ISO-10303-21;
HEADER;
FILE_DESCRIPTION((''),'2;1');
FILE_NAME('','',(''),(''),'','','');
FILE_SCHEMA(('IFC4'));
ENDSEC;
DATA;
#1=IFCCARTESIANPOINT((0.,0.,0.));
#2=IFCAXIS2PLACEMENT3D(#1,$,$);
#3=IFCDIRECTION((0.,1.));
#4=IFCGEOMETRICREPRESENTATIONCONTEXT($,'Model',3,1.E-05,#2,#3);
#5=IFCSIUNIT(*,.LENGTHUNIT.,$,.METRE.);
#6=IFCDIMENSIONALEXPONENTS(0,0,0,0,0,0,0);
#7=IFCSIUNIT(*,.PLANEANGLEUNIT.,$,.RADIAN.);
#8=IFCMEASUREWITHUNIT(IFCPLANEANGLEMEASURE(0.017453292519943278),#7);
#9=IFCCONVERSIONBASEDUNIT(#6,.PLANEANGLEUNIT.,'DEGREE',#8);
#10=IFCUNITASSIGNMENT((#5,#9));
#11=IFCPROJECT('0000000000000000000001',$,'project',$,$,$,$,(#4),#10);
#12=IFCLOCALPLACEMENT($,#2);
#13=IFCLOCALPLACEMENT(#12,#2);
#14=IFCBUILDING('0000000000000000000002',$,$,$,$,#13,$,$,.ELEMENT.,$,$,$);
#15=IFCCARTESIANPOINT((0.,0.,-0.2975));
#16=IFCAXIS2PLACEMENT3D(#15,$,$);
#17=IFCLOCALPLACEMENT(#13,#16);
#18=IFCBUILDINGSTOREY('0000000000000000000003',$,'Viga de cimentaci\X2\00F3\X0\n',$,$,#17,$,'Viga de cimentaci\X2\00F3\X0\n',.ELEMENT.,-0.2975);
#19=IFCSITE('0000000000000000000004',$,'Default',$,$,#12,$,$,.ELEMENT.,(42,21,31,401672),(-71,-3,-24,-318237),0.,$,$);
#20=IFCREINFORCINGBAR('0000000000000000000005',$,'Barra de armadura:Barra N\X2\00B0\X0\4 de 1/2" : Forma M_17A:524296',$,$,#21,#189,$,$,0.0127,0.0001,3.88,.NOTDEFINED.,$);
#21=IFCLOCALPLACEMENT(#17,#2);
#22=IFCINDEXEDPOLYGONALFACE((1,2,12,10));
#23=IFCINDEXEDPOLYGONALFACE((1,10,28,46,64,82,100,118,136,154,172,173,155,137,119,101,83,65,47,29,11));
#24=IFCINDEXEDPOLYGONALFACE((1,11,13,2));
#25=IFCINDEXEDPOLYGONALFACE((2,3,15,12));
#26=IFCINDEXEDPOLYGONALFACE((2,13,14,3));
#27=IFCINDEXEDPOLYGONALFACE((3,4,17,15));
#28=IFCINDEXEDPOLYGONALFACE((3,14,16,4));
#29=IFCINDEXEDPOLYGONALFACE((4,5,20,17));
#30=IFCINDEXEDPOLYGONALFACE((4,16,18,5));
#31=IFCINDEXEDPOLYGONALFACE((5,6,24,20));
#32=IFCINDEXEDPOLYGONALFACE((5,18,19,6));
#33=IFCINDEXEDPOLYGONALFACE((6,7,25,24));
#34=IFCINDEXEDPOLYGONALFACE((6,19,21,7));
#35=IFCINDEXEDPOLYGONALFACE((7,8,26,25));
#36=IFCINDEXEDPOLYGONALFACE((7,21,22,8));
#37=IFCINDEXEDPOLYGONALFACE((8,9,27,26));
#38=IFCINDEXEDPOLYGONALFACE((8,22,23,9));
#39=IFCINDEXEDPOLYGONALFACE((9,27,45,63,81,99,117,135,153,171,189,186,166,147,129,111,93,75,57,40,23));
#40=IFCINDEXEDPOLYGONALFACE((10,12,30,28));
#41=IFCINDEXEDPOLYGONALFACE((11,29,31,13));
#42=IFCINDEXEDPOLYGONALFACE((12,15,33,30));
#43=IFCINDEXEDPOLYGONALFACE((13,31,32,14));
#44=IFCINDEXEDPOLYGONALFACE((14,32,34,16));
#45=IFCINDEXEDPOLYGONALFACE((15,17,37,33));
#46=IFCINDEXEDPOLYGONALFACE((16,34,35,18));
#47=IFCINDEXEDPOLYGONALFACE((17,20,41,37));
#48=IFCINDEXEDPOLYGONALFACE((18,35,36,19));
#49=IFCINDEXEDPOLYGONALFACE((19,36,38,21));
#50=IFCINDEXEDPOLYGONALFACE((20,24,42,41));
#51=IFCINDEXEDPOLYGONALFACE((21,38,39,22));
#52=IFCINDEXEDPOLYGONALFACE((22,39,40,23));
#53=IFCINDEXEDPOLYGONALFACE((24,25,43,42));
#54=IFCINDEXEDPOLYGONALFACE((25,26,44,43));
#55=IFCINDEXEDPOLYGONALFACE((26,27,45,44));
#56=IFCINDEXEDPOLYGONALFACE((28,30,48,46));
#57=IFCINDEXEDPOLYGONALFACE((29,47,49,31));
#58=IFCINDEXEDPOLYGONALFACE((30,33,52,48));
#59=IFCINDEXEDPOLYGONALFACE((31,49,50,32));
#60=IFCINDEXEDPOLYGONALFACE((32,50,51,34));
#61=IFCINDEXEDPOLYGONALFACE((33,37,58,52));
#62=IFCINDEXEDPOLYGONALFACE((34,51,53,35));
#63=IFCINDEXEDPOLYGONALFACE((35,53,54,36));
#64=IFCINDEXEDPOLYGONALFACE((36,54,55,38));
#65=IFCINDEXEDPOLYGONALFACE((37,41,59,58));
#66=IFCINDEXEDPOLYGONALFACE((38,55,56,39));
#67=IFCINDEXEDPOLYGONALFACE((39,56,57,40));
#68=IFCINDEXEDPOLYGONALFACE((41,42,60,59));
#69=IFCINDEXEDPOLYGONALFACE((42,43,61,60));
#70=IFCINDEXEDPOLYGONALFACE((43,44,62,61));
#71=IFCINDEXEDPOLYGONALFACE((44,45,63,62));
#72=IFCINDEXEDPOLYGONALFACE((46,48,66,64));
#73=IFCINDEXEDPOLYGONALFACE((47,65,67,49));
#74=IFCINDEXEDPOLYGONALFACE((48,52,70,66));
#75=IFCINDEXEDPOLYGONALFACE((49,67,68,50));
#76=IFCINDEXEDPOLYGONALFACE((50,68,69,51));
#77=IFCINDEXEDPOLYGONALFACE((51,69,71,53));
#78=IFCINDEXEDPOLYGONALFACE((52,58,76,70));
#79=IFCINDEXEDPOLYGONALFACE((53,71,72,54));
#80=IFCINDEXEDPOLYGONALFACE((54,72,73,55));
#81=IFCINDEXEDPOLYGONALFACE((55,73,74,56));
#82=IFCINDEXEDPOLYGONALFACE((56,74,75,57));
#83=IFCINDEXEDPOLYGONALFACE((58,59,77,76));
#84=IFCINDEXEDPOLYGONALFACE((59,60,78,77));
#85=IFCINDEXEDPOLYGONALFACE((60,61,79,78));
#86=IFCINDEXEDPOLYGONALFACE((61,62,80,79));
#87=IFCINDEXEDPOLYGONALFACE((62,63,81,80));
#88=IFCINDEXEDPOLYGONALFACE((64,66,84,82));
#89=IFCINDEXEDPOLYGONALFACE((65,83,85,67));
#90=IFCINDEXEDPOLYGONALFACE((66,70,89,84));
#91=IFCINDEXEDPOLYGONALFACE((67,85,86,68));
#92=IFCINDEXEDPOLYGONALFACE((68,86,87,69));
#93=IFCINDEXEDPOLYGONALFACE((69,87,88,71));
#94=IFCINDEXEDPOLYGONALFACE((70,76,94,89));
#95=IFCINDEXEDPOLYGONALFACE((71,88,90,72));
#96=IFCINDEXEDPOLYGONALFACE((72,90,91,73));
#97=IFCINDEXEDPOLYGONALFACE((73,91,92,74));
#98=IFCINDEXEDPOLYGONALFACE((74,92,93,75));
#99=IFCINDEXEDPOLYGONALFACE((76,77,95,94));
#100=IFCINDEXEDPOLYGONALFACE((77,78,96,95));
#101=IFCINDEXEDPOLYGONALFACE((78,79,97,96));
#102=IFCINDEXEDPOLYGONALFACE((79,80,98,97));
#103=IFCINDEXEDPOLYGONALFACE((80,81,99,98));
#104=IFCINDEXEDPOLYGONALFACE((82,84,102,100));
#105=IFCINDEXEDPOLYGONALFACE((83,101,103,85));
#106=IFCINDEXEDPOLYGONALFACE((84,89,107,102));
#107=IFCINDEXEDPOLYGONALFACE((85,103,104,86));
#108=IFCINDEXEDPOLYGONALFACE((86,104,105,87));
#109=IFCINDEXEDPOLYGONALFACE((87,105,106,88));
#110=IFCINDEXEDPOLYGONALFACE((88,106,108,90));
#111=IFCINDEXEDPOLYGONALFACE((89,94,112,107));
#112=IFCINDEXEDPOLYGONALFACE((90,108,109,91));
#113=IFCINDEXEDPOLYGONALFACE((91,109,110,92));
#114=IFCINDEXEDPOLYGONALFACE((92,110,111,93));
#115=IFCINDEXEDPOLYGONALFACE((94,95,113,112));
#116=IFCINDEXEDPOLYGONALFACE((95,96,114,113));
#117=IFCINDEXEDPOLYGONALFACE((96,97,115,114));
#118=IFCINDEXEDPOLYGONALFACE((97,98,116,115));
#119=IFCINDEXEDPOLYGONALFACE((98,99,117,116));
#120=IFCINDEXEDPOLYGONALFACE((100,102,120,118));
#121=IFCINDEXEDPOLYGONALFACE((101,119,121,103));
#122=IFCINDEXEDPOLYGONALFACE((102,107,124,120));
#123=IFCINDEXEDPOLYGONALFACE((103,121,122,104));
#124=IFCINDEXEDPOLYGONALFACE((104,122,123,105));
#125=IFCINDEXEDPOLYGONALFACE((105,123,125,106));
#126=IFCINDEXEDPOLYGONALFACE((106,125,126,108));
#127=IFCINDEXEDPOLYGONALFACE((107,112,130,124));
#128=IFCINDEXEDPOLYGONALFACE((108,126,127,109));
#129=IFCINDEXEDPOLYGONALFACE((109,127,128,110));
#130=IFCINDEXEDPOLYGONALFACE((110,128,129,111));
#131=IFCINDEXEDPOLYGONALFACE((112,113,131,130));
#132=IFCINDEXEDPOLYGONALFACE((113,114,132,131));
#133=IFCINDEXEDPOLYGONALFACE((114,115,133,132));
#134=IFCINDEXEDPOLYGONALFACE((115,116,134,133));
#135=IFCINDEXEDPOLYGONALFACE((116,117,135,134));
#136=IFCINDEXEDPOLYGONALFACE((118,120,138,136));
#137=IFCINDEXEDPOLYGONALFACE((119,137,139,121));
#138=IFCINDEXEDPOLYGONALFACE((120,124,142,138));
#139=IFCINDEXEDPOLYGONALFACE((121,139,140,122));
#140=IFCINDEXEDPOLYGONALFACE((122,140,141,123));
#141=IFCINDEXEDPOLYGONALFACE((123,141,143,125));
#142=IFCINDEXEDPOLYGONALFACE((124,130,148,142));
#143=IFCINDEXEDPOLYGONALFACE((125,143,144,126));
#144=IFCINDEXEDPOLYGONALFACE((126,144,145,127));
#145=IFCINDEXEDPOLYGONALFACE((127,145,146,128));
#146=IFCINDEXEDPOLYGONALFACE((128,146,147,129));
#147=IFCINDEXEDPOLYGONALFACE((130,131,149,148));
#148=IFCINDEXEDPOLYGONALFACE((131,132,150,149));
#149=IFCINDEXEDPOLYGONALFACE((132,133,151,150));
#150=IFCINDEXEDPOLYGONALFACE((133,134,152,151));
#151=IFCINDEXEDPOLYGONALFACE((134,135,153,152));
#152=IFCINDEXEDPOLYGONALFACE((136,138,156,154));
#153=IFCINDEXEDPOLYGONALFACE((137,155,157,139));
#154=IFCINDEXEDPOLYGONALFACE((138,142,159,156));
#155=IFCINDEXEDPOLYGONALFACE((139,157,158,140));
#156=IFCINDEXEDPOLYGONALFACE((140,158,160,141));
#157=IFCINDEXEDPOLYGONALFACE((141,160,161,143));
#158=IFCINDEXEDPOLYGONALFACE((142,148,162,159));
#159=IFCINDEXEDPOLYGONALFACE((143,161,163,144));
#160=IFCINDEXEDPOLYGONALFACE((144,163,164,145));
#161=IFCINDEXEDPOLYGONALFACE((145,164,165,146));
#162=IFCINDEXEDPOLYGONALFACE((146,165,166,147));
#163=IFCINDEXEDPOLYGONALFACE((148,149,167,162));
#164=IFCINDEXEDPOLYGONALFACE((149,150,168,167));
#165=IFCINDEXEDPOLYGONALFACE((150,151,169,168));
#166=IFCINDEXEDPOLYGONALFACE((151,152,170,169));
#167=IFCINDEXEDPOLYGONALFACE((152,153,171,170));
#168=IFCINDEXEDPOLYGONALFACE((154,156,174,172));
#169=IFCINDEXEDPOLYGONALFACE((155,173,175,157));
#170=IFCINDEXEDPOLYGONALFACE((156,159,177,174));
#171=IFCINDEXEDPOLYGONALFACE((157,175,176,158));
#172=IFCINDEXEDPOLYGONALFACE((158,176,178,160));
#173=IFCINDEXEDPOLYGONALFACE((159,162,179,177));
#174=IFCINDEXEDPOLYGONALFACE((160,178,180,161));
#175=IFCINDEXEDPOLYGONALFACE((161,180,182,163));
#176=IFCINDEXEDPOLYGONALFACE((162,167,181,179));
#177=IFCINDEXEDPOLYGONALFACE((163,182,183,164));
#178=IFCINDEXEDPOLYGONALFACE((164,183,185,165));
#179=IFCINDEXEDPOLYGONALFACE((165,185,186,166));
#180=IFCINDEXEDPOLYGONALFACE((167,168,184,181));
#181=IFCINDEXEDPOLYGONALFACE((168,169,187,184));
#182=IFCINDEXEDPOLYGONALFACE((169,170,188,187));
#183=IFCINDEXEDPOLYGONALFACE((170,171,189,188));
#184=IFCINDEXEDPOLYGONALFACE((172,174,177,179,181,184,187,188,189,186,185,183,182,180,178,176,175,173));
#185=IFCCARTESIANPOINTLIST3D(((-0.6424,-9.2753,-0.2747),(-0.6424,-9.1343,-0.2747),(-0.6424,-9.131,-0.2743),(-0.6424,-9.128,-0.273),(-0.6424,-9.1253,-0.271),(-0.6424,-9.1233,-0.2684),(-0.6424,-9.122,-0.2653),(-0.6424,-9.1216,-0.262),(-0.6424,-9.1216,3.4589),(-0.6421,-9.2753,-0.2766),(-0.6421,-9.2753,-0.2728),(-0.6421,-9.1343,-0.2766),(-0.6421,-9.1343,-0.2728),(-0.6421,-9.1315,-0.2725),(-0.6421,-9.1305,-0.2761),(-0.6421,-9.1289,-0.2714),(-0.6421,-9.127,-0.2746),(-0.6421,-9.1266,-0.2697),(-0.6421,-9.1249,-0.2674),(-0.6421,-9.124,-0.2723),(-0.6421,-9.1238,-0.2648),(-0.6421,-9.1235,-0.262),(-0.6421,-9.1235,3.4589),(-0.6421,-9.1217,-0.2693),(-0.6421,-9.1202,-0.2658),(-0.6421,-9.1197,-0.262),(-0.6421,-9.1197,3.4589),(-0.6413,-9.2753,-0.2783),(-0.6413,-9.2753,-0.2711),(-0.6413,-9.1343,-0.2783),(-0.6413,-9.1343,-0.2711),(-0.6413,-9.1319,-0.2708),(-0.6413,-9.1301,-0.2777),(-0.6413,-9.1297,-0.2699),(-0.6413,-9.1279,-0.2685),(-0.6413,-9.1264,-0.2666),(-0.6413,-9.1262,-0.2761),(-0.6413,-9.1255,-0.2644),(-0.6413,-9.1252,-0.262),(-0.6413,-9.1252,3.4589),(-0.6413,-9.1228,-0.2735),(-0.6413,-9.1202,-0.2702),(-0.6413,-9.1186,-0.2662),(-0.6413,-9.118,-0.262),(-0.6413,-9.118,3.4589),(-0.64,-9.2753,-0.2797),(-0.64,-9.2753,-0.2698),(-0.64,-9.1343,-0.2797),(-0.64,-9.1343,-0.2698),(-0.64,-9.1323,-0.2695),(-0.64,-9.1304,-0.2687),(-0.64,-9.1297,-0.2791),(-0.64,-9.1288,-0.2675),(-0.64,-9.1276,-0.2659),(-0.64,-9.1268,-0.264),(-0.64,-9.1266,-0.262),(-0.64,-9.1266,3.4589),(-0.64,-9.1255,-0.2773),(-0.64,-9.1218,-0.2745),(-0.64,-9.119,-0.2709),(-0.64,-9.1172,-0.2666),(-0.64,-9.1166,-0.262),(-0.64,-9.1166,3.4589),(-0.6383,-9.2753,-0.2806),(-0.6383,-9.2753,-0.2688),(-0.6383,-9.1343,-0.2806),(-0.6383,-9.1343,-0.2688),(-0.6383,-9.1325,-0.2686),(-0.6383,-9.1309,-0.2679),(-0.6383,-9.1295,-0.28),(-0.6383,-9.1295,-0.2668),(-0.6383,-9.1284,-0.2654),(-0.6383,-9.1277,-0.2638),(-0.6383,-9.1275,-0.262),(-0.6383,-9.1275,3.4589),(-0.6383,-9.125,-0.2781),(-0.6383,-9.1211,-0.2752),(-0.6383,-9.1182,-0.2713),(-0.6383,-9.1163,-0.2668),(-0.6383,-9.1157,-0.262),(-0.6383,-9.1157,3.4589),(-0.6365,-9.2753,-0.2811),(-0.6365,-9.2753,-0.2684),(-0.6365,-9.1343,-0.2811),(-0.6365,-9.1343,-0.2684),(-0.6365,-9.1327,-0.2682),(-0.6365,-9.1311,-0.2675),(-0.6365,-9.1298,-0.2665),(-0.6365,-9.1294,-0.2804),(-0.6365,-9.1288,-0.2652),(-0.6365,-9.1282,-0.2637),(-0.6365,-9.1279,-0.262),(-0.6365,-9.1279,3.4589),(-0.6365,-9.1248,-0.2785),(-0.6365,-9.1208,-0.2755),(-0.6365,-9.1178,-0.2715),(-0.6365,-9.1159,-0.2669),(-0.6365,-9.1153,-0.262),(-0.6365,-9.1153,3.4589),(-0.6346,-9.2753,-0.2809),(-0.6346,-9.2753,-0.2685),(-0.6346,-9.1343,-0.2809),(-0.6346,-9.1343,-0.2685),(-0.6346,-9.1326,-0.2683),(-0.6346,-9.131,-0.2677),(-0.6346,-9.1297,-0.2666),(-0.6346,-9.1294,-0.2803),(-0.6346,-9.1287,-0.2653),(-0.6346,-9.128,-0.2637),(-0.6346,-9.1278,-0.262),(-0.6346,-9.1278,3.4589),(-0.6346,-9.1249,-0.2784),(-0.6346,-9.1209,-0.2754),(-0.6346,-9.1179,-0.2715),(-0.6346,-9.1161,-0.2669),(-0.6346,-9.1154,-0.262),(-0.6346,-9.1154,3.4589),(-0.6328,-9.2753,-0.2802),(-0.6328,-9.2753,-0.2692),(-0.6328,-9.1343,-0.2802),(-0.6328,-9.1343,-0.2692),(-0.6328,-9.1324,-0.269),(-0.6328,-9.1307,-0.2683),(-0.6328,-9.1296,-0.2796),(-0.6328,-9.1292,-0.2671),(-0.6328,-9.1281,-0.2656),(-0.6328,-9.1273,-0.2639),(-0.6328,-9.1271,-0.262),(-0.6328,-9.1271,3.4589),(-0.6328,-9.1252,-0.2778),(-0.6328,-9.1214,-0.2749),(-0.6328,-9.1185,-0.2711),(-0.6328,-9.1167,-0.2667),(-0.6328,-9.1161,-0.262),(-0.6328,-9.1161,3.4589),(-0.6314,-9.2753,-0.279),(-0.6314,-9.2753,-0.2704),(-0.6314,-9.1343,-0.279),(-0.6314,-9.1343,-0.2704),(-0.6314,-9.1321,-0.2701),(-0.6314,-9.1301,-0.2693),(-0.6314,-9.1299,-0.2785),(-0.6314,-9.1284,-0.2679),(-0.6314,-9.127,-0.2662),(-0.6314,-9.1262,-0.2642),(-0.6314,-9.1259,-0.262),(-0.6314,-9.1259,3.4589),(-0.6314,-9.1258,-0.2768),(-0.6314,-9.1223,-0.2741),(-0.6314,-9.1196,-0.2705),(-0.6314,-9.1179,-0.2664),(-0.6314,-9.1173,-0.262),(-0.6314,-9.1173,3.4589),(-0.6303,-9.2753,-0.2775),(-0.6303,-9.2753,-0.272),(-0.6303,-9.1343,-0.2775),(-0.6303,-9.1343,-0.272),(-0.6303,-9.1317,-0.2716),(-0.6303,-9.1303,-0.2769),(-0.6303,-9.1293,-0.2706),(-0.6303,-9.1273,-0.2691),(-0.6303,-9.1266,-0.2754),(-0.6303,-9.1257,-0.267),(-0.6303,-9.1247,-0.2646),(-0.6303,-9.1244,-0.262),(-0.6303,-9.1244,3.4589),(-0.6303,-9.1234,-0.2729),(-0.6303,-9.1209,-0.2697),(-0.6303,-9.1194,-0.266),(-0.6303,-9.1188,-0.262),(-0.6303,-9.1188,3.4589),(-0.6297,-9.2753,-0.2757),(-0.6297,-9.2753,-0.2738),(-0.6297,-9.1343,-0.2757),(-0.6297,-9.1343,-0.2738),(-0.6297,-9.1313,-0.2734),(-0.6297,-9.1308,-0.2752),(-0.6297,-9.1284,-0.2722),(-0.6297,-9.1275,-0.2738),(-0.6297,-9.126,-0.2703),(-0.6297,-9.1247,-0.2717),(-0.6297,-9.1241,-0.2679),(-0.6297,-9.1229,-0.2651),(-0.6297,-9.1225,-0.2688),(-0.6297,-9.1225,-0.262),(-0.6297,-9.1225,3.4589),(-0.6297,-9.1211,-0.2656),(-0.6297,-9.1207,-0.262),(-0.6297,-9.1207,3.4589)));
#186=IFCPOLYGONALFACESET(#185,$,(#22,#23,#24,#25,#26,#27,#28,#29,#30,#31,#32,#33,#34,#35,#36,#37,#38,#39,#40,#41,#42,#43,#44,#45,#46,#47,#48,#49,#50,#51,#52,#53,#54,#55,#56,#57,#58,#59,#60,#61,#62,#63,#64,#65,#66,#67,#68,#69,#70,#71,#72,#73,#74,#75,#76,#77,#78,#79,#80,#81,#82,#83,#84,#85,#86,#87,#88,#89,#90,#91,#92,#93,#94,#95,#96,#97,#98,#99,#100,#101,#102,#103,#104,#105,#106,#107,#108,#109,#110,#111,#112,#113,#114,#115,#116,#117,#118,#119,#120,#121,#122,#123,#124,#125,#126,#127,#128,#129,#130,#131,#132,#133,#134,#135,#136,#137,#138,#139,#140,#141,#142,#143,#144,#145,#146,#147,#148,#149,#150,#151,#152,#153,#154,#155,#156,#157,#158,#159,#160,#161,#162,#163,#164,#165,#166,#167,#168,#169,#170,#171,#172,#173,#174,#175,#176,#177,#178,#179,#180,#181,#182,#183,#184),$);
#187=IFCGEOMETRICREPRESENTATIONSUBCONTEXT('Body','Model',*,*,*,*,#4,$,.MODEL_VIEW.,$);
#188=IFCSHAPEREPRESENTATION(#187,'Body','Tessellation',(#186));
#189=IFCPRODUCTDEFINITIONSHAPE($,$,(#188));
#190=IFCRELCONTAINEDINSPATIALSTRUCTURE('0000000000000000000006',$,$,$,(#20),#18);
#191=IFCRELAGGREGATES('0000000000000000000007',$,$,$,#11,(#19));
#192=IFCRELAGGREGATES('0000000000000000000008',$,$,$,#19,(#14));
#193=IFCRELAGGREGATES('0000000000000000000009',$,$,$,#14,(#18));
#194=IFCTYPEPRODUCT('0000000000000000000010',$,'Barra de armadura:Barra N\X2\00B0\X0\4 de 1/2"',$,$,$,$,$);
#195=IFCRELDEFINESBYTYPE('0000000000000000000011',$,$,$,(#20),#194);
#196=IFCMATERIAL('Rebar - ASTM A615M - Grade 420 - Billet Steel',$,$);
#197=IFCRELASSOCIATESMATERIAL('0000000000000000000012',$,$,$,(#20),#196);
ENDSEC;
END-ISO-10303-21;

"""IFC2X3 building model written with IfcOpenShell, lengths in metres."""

from ifc_helpers import new_model, entity, si_unit, converted_unit, direction, frame, origin, place, context, subcontext, project, spatial, material, type_object, element, save


model = new_model("IFC2X3")

# Units and contexts
model_context = context("Model", 3, precision=1e-05, world=origin(), true_north=direction((0.0, 1.0)))
body_context = subcontext(model_context, "Body", "Model", "MODEL_VIEW")
ifc_project = project(units=[si_unit("LENGTHUNIT", "METRE"), converted_unit("PLANEANGLEUNIT", "DEGREE", entity("IfcPlaneAngleMeasure", 0.017453292519943278), si_unit("PLANEANGLEUNIT", "RADIAN"), dimensions=[0, 0, 0, 0, 0, 0, 0])], contexts=[model_context])

# Site, building, storey
site_placement = place(None, origin())
site = spatial("IfcSite", under=ifc_project, at=site_placement, Name="Default", CompositionType="ELEMENT", RefLatitude=(42, 21, 31, 401672), RefLongitude=(-71, -3, -24, -318237), RefElevation=0.0)
building_placement = place(site_placement, origin())
building = spatial("IfcBuilding", under=site, at=building_placement, CompositionType="ELEMENT")
storey_placement = place(building_placement, frame((0.0, 0.0, -0.2975)))
storey = spatial("IfcBuildingStorey", under=building, at=storey_placement, Name="Viga de cimentación", LongName="Viga de cimentación", CompositionType="ELEMENT", Elevation=-0.2975)

# Reinforcing bar
ifc_material = material(Name="Rebar - ASTM A615M - Grade 420 - Billet Steel")
type_product_1 = type_object("IfcTypeProduct", Name="Barra de armadura:Barra N°4 de 1/2\"")
reinforcing_bar_1_placement = place(storey_placement, origin())
element("IfcReinforcingBar", 1, at=reinforcing_bar_1_placement, inside=storey, type_object=type_product_1, material=ifc_material, Name="Barra de armadura:Barra N°4 de 1/2\" : Forma M_17A:524296", BarLength=3.88, BarRole="NOTDEFINED", CrossSectionArea=0.0001, NominalDiameter=0.0127, context=body_context, shape_type="AdvancedSweptSolid", body=[
    entity("IfcSweptDiskSolid", entity("IfcCompositeCurve", [entity("IfcCompositeCurveSegment", "CONTINUOUS", True, entity("IfcPolyline", [entity("IfcCartesianPoint", [-0.636, -9.1216, 3.4589]), entity("IfcCartesianPoint", [-0.636, -9.1216, -0.262])])), entity("IfcCompositeCurveSegment", "CONTINUOUS", True, entity("IfcTrimmedCurve", entity("IfcCircle", entity("IfcAxis2Placement3D", entity("IfcCartesianPoint", [-0.636, -9.1343, -0.262]), entity("IfcDirection", [-1.0, 0.0, 0.0]), entity("IfcDirection", [0.0, 0.0, -1.0])), 0.0127), [entity("IfcParameterValue", 270.0)], [entity("IfcParameterValue", 360.0)], True, "PARAMETER")), entity("IfcCompositeCurveSegment", "CONTINUOUS", True, entity("IfcPolyline", [entity("IfcCartesianPoint", [-0.636, -9.1343, -0.2747]), entity("IfcCartesianPoint", [-0.636, -9.2753, -0.2747])]))], False), 0.0063, None, 0.0, 92.0),
])

save(model, "model.ifc")
